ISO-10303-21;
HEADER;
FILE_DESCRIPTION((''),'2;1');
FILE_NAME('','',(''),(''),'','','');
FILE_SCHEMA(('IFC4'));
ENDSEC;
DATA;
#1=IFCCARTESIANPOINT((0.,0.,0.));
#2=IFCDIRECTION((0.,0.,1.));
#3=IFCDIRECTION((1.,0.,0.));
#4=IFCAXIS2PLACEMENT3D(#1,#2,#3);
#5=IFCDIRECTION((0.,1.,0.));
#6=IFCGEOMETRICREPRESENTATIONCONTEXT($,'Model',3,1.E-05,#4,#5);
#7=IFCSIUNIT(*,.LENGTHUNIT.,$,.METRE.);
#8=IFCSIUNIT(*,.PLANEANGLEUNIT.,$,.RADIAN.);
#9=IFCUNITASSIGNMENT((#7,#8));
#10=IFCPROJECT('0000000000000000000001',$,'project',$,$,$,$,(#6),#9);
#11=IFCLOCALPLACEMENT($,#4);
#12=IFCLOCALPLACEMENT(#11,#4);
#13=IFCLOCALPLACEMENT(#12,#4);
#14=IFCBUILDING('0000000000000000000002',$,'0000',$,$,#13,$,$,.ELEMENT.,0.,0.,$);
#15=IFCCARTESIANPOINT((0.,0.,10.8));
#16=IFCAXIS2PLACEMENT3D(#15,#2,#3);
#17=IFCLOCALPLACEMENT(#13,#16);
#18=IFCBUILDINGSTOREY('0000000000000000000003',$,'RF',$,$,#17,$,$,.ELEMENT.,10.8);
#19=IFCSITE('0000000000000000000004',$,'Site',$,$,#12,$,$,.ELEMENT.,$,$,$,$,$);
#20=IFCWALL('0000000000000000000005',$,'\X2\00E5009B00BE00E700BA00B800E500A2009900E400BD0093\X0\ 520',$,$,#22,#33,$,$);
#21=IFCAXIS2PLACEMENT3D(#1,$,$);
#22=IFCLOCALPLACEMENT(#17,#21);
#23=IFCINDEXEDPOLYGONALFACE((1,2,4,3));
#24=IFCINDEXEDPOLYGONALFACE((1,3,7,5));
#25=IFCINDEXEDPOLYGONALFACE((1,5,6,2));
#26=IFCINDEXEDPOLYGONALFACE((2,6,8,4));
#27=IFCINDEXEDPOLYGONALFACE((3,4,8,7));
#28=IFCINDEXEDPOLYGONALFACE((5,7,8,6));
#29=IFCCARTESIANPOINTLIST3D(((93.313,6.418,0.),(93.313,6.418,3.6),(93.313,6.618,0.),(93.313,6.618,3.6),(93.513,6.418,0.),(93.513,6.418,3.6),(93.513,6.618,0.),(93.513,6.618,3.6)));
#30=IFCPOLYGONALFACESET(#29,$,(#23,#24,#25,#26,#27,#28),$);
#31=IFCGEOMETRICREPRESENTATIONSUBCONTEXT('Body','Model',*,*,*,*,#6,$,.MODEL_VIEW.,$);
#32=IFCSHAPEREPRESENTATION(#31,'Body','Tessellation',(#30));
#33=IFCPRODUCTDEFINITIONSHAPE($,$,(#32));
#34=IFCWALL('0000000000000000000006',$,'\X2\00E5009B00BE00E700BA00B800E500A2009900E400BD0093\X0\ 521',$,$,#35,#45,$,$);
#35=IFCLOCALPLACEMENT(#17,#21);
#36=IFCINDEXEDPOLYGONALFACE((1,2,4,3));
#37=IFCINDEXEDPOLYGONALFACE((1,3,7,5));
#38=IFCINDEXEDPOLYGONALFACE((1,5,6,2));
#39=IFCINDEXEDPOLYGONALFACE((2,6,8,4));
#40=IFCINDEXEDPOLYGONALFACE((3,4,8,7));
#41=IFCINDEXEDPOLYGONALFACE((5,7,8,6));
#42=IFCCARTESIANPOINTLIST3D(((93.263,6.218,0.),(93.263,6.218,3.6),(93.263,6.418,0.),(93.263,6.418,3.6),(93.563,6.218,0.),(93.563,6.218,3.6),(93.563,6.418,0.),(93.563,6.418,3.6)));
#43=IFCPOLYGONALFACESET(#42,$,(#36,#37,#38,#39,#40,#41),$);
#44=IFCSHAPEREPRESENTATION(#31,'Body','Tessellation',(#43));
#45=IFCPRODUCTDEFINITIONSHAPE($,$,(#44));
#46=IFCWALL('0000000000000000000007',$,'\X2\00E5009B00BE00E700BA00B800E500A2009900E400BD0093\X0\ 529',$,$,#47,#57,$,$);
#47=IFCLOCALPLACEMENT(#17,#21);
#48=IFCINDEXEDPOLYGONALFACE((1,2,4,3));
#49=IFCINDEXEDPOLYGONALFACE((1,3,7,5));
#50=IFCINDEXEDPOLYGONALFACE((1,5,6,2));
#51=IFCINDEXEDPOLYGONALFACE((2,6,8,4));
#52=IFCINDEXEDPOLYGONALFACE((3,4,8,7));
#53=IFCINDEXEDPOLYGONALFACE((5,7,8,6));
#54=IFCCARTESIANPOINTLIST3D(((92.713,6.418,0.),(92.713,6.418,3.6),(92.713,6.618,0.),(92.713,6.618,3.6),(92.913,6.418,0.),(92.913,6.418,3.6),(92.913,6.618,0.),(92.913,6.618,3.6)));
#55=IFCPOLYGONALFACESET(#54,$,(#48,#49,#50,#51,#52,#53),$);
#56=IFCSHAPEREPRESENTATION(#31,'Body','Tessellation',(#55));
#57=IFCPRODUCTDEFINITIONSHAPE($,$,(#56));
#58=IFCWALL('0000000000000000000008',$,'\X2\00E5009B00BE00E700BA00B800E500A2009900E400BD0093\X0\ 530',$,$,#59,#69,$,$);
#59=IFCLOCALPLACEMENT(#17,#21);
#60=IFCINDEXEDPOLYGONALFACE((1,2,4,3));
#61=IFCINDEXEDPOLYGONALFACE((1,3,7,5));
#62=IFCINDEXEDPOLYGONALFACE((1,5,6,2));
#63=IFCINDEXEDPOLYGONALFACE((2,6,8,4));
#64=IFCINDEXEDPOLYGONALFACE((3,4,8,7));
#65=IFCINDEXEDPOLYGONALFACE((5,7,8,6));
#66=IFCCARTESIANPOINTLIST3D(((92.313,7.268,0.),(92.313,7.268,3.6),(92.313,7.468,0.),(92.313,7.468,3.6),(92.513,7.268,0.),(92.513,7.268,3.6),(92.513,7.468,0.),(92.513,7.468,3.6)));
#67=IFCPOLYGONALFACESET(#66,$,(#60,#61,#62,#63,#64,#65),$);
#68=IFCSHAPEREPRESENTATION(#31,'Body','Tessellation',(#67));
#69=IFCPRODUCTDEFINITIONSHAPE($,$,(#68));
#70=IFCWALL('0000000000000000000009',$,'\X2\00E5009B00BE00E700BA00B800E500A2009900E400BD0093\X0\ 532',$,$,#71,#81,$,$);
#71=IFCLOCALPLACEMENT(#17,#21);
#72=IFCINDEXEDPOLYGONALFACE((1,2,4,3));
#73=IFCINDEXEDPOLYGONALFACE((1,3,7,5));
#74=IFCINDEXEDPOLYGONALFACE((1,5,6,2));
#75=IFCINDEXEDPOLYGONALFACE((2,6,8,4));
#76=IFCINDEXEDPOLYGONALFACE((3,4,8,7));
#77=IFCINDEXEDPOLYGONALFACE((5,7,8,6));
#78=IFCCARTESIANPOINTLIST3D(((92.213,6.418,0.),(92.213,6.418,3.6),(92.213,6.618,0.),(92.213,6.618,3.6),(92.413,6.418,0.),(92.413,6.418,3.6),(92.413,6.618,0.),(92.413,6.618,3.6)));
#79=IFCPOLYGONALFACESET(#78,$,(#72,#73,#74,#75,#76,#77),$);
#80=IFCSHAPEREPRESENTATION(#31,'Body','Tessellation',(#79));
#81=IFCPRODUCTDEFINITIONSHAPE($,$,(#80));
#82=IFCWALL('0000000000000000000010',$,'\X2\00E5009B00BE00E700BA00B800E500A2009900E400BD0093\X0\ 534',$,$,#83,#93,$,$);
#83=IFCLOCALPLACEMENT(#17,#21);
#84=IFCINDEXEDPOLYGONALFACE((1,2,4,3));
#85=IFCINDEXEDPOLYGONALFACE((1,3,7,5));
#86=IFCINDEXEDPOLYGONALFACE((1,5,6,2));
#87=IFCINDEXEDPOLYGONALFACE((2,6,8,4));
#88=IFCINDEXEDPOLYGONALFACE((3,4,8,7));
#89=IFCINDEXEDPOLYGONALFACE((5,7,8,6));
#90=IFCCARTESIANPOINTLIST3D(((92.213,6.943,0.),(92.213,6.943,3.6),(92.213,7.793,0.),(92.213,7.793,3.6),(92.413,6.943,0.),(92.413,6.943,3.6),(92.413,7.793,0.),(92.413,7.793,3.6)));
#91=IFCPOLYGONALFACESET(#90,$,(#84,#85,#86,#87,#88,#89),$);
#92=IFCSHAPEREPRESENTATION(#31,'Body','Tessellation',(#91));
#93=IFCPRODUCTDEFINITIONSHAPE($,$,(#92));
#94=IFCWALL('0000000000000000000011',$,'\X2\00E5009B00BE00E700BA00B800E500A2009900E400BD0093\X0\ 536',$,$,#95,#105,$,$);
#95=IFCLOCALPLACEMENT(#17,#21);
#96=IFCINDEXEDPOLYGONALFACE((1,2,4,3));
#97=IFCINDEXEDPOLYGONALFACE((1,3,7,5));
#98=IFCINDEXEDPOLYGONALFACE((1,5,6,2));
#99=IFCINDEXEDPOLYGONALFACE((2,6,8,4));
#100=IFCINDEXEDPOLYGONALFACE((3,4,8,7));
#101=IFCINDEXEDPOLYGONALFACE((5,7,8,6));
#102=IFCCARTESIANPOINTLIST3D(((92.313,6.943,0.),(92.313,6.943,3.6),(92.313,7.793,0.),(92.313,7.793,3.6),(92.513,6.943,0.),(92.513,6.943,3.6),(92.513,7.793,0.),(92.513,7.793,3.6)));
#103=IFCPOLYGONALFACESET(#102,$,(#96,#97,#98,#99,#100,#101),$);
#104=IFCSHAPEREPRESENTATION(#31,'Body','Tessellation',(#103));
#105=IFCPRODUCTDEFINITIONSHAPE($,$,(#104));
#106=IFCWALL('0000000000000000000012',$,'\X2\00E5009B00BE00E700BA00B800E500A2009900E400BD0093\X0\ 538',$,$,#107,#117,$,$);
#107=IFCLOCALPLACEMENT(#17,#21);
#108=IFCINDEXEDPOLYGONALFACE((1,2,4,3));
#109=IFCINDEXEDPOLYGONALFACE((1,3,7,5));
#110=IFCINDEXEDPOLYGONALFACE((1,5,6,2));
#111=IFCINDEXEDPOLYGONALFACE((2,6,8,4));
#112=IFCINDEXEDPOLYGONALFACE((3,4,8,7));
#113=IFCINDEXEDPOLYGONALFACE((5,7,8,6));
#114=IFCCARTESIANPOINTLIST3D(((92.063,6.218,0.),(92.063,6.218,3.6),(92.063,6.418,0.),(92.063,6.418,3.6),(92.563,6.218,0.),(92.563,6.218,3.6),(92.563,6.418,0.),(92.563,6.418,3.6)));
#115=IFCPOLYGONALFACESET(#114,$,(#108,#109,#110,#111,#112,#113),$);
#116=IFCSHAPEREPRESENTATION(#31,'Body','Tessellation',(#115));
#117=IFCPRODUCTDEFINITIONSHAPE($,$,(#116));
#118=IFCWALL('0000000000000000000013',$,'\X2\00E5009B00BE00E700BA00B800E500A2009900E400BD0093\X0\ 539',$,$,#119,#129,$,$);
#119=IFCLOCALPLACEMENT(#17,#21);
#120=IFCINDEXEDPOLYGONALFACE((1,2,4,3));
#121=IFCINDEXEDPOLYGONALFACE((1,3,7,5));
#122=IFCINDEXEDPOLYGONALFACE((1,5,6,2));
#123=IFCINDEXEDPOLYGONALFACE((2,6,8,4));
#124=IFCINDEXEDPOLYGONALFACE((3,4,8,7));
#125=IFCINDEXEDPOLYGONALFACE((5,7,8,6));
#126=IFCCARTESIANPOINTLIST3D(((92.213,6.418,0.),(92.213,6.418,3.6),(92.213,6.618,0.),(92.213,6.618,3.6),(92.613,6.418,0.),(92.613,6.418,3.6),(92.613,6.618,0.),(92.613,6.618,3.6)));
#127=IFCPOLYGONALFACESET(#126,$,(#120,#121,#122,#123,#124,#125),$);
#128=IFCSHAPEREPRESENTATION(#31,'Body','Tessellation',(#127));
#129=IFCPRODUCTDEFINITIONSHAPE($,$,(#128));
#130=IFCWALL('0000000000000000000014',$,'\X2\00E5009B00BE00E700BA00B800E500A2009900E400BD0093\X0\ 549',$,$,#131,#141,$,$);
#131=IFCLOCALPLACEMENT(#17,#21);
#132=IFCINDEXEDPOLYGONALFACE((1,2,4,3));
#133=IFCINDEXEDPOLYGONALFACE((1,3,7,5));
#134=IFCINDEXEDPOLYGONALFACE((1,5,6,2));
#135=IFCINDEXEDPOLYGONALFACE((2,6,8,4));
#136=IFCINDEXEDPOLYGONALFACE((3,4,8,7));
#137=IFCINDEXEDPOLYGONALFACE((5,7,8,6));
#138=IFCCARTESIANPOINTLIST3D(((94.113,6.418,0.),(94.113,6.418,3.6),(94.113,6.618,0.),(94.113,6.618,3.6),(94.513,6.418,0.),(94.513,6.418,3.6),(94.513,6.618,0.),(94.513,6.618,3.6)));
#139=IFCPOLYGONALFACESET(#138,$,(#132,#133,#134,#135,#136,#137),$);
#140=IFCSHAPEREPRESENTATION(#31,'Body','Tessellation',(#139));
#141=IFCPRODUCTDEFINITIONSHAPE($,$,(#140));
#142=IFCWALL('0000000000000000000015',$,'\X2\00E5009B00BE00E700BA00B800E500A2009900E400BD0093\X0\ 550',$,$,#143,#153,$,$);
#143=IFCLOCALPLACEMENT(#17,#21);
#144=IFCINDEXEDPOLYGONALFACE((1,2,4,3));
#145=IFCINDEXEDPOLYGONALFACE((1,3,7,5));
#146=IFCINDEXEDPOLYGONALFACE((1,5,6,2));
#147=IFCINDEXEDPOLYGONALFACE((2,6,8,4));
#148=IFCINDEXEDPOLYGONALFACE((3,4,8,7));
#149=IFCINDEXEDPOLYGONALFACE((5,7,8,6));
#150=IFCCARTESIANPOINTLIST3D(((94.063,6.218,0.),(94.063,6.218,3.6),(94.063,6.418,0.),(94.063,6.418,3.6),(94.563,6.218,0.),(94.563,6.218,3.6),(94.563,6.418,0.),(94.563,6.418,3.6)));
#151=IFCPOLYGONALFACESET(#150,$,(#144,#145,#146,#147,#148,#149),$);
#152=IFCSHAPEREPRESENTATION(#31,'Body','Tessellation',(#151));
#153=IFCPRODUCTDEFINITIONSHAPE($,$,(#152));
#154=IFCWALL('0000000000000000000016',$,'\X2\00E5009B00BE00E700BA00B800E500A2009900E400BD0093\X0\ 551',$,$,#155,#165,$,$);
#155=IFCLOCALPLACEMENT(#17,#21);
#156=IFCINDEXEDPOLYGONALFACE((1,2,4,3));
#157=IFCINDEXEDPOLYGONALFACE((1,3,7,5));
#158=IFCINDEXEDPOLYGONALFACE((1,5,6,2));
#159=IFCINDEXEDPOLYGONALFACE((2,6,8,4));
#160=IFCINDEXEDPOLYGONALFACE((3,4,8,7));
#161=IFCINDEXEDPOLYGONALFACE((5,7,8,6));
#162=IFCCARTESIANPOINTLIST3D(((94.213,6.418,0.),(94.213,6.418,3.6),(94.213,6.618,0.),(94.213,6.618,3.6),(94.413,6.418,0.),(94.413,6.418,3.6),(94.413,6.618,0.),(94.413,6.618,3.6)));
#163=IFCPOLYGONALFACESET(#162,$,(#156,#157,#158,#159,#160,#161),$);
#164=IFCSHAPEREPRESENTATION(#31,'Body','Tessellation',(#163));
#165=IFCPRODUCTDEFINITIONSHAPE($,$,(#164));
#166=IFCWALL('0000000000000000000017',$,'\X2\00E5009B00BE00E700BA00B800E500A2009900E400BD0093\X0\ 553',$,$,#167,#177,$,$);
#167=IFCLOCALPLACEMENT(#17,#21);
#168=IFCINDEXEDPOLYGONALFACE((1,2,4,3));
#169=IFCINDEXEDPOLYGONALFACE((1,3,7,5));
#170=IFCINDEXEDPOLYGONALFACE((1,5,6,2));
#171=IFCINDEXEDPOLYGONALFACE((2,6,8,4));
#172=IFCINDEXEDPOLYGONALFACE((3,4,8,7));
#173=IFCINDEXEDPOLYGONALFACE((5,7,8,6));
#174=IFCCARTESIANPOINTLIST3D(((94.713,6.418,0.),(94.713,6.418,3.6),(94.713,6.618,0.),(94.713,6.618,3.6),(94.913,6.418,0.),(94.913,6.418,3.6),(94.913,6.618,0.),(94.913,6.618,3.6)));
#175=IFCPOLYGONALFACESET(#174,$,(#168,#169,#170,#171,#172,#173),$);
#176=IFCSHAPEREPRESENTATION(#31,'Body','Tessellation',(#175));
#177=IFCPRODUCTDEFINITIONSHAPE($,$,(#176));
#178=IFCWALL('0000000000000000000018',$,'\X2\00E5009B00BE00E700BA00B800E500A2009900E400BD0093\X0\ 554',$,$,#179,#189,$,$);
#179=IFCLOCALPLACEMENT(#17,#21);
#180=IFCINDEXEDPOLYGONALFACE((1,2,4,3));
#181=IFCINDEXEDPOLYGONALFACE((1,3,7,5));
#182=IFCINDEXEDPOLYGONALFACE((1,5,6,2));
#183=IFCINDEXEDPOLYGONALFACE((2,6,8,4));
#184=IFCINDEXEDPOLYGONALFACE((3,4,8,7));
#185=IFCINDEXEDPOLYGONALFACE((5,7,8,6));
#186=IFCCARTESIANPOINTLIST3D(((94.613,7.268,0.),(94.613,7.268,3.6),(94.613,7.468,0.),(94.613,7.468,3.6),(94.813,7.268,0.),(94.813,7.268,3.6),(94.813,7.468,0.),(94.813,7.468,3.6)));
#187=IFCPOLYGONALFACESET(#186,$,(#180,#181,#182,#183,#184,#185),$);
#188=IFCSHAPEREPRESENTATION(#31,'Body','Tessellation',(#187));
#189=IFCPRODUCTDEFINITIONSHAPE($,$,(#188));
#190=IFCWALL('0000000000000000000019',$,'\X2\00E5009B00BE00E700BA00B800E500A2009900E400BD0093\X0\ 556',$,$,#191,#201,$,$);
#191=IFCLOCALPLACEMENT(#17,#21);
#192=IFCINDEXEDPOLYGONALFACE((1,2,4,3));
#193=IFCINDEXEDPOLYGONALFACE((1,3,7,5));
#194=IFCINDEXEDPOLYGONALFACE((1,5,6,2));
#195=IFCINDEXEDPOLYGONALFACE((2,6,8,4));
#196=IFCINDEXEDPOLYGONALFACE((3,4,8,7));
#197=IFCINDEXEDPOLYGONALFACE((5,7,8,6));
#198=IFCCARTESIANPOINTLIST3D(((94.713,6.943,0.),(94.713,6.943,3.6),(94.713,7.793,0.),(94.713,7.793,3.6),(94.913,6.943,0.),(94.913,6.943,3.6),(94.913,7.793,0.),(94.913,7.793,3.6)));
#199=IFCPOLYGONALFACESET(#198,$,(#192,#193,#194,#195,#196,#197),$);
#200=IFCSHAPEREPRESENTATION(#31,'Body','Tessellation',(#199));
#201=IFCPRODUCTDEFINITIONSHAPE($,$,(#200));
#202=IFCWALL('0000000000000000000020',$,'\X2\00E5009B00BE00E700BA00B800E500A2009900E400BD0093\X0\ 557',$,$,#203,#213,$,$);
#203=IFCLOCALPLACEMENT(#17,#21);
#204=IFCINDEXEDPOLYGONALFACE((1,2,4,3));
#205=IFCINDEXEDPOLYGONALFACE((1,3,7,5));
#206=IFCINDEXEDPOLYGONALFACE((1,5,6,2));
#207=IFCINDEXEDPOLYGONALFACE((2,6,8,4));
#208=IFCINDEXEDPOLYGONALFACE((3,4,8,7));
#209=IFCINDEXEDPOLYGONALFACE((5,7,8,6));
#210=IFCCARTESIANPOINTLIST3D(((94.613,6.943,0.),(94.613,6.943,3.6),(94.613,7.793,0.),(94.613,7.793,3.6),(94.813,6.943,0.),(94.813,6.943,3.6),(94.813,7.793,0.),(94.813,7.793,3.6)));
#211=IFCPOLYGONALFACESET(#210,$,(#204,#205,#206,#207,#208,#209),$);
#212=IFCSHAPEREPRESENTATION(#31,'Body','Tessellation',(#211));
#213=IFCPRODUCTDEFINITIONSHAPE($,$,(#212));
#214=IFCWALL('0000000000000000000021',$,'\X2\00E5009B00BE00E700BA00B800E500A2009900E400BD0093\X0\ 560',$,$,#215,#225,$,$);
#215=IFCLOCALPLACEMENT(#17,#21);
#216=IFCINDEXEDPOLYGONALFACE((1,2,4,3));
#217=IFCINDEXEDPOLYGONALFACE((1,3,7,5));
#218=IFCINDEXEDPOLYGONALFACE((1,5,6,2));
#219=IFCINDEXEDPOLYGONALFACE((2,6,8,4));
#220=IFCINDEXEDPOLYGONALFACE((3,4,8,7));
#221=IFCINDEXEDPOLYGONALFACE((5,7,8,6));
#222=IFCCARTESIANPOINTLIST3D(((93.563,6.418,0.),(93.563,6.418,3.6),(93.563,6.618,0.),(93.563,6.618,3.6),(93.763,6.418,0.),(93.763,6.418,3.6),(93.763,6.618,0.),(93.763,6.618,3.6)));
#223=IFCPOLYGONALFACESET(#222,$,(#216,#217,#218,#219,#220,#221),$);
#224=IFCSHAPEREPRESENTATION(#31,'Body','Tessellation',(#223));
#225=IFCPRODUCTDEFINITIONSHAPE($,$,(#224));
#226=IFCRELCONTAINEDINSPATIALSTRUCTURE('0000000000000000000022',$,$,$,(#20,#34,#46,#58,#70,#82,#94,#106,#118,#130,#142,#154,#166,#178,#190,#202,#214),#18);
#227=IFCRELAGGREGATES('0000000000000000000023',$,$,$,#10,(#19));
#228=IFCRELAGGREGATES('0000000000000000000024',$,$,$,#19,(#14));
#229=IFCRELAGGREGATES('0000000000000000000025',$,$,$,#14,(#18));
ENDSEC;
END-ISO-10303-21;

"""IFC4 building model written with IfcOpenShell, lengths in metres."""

from ifc_helpers import new_model, si_unit, direction, frame, frame_2d, origin_with_axes, place, context, subcontext, project, spatial, rectangle, extrude, element, save


model = new_model("IFC4")

# Units and contexts
model_context = context("Model", 3, precision=1e-05, world=origin_with_axes(), true_north=direction((0.0, 1.0, 0.0)))
body_context = subcontext(model_context, "Body", "Model", "MODEL_VIEW")
ifc_project = project(units=[si_unit("LENGTHUNIT", "METRE"), si_unit("PLANEANGLEUNIT", "RADIAN")], contexts=[model_context])

# Site, building, storey
placement = place(None, origin_with_axes())
site_placement = place(placement, origin_with_axes())
site = spatial("IfcSite", under=ifc_project, at=site_placement, Name="Site", CompositionType="ELEMENT")
building_placement = place(site_placement, origin_with_axes())
building = spatial("IfcBuilding", under=site, at=building_placement, Name="0000", CompositionType="ELEMENT", ElevationOfRefHeight=0.0, ElevationOfTerrain=0.0)
storey_placement = place(building_placement, frame((0.0, 0.0, 10.8), z_axis=(0.0, 0.0, 1.0), x_axis=(1.0, 0.0, 0.0)))
storey = spatial("IfcBuildingStorey", under=building, at=storey_placement, Name="RF", CompositionType="ELEMENT", Elevation=10.8)

# Walls
wall_1_placement = place(storey_placement, frame((93.413, 6.518, 0.0), z_axis=(0.0, 0.0, 1.0), x_axis=(1.0, 0.0, 0.0)))
element("IfcWall", 1, at=wall_1_placement, inside=storey, Name="å\u009b¾çº¸å¢\u0099ä½\u0093 520", context=body_context, shape_type="SweptSolid", body=[
    extrude(rectangle(XDim=0.2, YDim=0.2, at=frame_2d((0.0, 0.0), x_axis=(1.0, 0.0, 0.0))), frame((0.0, 0.0, 0.0), z_axis=(0.0, 0.0, 1.0)), (0.0, 0.0, 1.0), 3.6),
])
wall_2_placement = place(storey_placement, frame((93.413, 6.318, 0.0), z_axis=(0.0, 0.0, 1.0), x_axis=(1.0, 0.0, 0.0)))
element("IfcWall", 2, at=wall_2_placement, inside=storey, Name="å\u009b¾çº¸å¢\u0099ä½\u0093 521", context=body_context, shape_type="SweptSolid", body=[
    extrude(rectangle(XDim=0.3, YDim=0.2, at=frame_2d((0.0, 0.0), x_axis=(1.0, 0.0, 0.0))), frame((0.0, 0.0, 0.0), z_axis=(0.0, 0.0, 1.0)), (0.0, 0.0, 1.0), 3.6),
])
for number, where, z_axis, x_axis, name in (
    (3, (92.813, 6.518, 0.0), (0.0, 0.0, 1.0), (0.0, -1.0, 0.0), "å\u009b¾çº¸å¢\u0099ä½\u0093 529"),
    (4, (92.413, 7.368, 0.0), (0.0, 0.0, 1.0), (-1.0, 0.0, 0.0), "å\u009b¾çº¸å¢\u0099ä½\u0093 530"),
    (5, (92.313, 6.518, 0.0), (0.0, 0.0, 1.0), (0.0, -1.0, 0.0), "å\u009b¾çº¸å¢\u0099ä½\u0093 532"),
):
    element("IfcWall", number, at=place(storey_placement, frame(where, z_axis=z_axis, x_axis=x_axis)), inside=storey, Name=name, context=body_context, shape_type="SweptSolid", body=[
        extrude(rectangle(XDim=0.2, YDim=0.2, at=frame_2d((0.0, 0.0), x_axis=(1.0, 0.0, 0.0))), frame((0.0, 0.0, 0.0), z_axis=(0.0, 0.0, 1.0)), (0.0, 0.0, 1.0), 3.6),
    ])
for number, where, z_axis, x_axis, name in (
    (6, (92.313, 7.368, 0.0), (0.0, 0.0, 1.0), (0.0, -1.0, 0.0), "å\u009b¾çº¸å¢\u0099ä½\u0093 534"),
    (7, (92.413, 7.368, 0.0), (0.0, 0.0, 1.0), (0.0, -1.0, 0.0), "å\u009b¾çº¸å¢\u0099ä½\u0093 536"),
):
    element("IfcWall", number, at=place(storey_placement, frame(where, z_axis=z_axis, x_axis=x_axis)), inside=storey, Name=name, context=body_context, shape_type="SweptSolid", body=[
        extrude(rectangle(XDim=0.85, YDim=0.2, at=frame_2d((0.0, 0.0), x_axis=(1.0, 0.0, 0.0))), frame((0.0, 0.0, 0.0), z_axis=(0.0, 0.0, 1.0)), (0.0, 0.0, 1.0), 3.6),
    ])
wall_3_placement = place(storey_placement, frame((92.313, 6.318, 0.0), z_axis=(0.0, 0.0, 1.0), x_axis=(1.0, 0.0, 0.0)))
element("IfcWall", 8, at=wall_3_placement, inside=storey, Name="å\u009b¾çº¸å¢\u0099ä½\u0093 538", context=body_context, shape_type="SweptSolid", body=[
    extrude(rectangle(XDim=0.5, YDim=0.2, at=frame_2d((0.0, 0.0), x_axis=(1.0, 0.0, 0.0))), frame((0.0, 0.0, 0.0), z_axis=(0.0, 0.0, 1.0)), (0.0, 0.0, 1.0), 3.6),
])
for number, where, z_axis, x_axis, name in (
    (9, (92.413, 6.518, 0.0), (0.0, 0.0, 1.0), (1.0, 0.0, 0.0), "å\u009b¾çº¸å¢\u0099ä½\u0093 539"),
    (10, (94.313, 6.518, 0.0), (0.0, 0.0, 1.0), (1.0, 0.0, 0.0), "å\u009b¾çº¸å¢\u0099ä½\u0093 549"),
):
    element("IfcWall", number, at=place(storey_placement, frame(where, z_axis=z_axis, x_axis=x_axis)), inside=storey, Name=name, context=body_context, shape_type="SweptSolid", body=[
        extrude(rectangle(XDim=0.4, YDim=0.2, at=frame_2d((0.0, 0.0), x_axis=(1.0, 0.0, 0.0))), frame((0.0, 0.0, 0.0), z_axis=(0.0, 0.0, 1.0)), (0.0, 0.0, 1.0), 3.6),
    ])
wall_4_placement = place(storey_placement, frame((94.313, 6.318, 0.0), z_axis=(0.0, 0.0, 1.0), x_axis=(1.0, 0.0, 0.0)))
element("IfcWall", 11, at=wall_4_placement, inside=storey, Name="å\u009b¾çº¸å¢\u0099ä½\u0093 550", context=body_context, shape_type="SweptSolid", body=[
    extrude(rectangle(XDim=0.5, YDim=0.2, at=frame_2d((0.0, 0.0), x_axis=(1.0, 0.0, 0.0))), frame((0.0, 0.0, 0.0), z_axis=(0.0, 0.0, 1.0)), (0.0, 0.0, 1.0), 3.6),
])
for number, where, z_axis, x_axis, name in (
    (12, (94.313, 6.518, 0.0), (0.0, 0.0, 1.0), (0.0, -1.0, 0.0), "å\u009b¾çº¸å¢\u0099ä½\u0093 551"),
    (13, (94.813, 6.518, 0.0), (0.0, 0.0, 1.0), (0.0, -1.0, 0.0), "å\u009b¾çº¸å¢\u0099ä½\u0093 553"),
    (14, (94.713, 7.368, 0.0), (0.0, 0.0, 1.0), (1.0, 0.0, 0.0), "å\u009b¾çº¸å¢\u0099ä½\u0093 554"),
):
    element("IfcWall", number, at=place(storey_placement, frame(where, z_axis=z_axis, x_axis=x_axis)), inside=storey, Name=name, context=body_context, shape_type="SweptSolid", body=[
        extrude(rectangle(XDim=0.2, YDim=0.2, at=frame_2d((0.0, 0.0), x_axis=(1.0, 0.0, 0.0))), frame((0.0, 0.0, 0.0), z_axis=(0.0, 0.0, 1.0)), (0.0, 0.0, 1.0), 3.6),
    ])
for number, where, z_axis, x_axis, name in (
    (15, (94.813, 7.368, 0.0), (0.0, 0.0, 1.0), (0.0, -1.0, 0.0), "å\u009b¾çº¸å¢\u0099ä½\u0093 556"),
    (16, (94.713, 7.368, 0.0), (0.0, 0.0, 1.0), (0.0, -1.0, 0.0), "å\u009b¾çº¸å¢\u0099ä½\u0093 557"),
):
    element("IfcWall", number, at=place(storey_placement, frame(where, z_axis=z_axis, x_axis=x_axis)), inside=storey, Name=name, context=body_context, shape_type="SweptSolid", body=[
        extrude(rectangle(XDim=0.85, YDim=0.2, at=frame_2d((0.0, 0.0), x_axis=(1.0, 0.0, 0.0))), frame((0.0, 0.0, 0.0), z_axis=(0.0, 0.0, 1.0)), (0.0, 0.0, 1.0), 3.6),
    ])
for number, where, z_axis, x_axis, name in (
    (17, (93.663, 6.518, 0.0), (0.0, 0.0, 1.0), (1.0, 0.0, 0.0), "å\u009b¾çº¸å¢\u0099ä½\u0093 560"),
):
    element("IfcWall", number, at=place(storey_placement, frame(where, z_axis=z_axis, x_axis=x_axis)), inside=storey, Name=name, context=body_context, shape_type="SweptSolid", body=[
        extrude(rectangle(XDim=0.2, YDim=0.2, at=frame_2d((0.0, 0.0), x_axis=(1.0, 0.0, 0.0))), frame((0.0, 0.0, 0.0), z_axis=(0.0, 0.0, 1.0)), (0.0, 0.0, 1.0), 3.6),
    ])

save(model, "model.ifc")
